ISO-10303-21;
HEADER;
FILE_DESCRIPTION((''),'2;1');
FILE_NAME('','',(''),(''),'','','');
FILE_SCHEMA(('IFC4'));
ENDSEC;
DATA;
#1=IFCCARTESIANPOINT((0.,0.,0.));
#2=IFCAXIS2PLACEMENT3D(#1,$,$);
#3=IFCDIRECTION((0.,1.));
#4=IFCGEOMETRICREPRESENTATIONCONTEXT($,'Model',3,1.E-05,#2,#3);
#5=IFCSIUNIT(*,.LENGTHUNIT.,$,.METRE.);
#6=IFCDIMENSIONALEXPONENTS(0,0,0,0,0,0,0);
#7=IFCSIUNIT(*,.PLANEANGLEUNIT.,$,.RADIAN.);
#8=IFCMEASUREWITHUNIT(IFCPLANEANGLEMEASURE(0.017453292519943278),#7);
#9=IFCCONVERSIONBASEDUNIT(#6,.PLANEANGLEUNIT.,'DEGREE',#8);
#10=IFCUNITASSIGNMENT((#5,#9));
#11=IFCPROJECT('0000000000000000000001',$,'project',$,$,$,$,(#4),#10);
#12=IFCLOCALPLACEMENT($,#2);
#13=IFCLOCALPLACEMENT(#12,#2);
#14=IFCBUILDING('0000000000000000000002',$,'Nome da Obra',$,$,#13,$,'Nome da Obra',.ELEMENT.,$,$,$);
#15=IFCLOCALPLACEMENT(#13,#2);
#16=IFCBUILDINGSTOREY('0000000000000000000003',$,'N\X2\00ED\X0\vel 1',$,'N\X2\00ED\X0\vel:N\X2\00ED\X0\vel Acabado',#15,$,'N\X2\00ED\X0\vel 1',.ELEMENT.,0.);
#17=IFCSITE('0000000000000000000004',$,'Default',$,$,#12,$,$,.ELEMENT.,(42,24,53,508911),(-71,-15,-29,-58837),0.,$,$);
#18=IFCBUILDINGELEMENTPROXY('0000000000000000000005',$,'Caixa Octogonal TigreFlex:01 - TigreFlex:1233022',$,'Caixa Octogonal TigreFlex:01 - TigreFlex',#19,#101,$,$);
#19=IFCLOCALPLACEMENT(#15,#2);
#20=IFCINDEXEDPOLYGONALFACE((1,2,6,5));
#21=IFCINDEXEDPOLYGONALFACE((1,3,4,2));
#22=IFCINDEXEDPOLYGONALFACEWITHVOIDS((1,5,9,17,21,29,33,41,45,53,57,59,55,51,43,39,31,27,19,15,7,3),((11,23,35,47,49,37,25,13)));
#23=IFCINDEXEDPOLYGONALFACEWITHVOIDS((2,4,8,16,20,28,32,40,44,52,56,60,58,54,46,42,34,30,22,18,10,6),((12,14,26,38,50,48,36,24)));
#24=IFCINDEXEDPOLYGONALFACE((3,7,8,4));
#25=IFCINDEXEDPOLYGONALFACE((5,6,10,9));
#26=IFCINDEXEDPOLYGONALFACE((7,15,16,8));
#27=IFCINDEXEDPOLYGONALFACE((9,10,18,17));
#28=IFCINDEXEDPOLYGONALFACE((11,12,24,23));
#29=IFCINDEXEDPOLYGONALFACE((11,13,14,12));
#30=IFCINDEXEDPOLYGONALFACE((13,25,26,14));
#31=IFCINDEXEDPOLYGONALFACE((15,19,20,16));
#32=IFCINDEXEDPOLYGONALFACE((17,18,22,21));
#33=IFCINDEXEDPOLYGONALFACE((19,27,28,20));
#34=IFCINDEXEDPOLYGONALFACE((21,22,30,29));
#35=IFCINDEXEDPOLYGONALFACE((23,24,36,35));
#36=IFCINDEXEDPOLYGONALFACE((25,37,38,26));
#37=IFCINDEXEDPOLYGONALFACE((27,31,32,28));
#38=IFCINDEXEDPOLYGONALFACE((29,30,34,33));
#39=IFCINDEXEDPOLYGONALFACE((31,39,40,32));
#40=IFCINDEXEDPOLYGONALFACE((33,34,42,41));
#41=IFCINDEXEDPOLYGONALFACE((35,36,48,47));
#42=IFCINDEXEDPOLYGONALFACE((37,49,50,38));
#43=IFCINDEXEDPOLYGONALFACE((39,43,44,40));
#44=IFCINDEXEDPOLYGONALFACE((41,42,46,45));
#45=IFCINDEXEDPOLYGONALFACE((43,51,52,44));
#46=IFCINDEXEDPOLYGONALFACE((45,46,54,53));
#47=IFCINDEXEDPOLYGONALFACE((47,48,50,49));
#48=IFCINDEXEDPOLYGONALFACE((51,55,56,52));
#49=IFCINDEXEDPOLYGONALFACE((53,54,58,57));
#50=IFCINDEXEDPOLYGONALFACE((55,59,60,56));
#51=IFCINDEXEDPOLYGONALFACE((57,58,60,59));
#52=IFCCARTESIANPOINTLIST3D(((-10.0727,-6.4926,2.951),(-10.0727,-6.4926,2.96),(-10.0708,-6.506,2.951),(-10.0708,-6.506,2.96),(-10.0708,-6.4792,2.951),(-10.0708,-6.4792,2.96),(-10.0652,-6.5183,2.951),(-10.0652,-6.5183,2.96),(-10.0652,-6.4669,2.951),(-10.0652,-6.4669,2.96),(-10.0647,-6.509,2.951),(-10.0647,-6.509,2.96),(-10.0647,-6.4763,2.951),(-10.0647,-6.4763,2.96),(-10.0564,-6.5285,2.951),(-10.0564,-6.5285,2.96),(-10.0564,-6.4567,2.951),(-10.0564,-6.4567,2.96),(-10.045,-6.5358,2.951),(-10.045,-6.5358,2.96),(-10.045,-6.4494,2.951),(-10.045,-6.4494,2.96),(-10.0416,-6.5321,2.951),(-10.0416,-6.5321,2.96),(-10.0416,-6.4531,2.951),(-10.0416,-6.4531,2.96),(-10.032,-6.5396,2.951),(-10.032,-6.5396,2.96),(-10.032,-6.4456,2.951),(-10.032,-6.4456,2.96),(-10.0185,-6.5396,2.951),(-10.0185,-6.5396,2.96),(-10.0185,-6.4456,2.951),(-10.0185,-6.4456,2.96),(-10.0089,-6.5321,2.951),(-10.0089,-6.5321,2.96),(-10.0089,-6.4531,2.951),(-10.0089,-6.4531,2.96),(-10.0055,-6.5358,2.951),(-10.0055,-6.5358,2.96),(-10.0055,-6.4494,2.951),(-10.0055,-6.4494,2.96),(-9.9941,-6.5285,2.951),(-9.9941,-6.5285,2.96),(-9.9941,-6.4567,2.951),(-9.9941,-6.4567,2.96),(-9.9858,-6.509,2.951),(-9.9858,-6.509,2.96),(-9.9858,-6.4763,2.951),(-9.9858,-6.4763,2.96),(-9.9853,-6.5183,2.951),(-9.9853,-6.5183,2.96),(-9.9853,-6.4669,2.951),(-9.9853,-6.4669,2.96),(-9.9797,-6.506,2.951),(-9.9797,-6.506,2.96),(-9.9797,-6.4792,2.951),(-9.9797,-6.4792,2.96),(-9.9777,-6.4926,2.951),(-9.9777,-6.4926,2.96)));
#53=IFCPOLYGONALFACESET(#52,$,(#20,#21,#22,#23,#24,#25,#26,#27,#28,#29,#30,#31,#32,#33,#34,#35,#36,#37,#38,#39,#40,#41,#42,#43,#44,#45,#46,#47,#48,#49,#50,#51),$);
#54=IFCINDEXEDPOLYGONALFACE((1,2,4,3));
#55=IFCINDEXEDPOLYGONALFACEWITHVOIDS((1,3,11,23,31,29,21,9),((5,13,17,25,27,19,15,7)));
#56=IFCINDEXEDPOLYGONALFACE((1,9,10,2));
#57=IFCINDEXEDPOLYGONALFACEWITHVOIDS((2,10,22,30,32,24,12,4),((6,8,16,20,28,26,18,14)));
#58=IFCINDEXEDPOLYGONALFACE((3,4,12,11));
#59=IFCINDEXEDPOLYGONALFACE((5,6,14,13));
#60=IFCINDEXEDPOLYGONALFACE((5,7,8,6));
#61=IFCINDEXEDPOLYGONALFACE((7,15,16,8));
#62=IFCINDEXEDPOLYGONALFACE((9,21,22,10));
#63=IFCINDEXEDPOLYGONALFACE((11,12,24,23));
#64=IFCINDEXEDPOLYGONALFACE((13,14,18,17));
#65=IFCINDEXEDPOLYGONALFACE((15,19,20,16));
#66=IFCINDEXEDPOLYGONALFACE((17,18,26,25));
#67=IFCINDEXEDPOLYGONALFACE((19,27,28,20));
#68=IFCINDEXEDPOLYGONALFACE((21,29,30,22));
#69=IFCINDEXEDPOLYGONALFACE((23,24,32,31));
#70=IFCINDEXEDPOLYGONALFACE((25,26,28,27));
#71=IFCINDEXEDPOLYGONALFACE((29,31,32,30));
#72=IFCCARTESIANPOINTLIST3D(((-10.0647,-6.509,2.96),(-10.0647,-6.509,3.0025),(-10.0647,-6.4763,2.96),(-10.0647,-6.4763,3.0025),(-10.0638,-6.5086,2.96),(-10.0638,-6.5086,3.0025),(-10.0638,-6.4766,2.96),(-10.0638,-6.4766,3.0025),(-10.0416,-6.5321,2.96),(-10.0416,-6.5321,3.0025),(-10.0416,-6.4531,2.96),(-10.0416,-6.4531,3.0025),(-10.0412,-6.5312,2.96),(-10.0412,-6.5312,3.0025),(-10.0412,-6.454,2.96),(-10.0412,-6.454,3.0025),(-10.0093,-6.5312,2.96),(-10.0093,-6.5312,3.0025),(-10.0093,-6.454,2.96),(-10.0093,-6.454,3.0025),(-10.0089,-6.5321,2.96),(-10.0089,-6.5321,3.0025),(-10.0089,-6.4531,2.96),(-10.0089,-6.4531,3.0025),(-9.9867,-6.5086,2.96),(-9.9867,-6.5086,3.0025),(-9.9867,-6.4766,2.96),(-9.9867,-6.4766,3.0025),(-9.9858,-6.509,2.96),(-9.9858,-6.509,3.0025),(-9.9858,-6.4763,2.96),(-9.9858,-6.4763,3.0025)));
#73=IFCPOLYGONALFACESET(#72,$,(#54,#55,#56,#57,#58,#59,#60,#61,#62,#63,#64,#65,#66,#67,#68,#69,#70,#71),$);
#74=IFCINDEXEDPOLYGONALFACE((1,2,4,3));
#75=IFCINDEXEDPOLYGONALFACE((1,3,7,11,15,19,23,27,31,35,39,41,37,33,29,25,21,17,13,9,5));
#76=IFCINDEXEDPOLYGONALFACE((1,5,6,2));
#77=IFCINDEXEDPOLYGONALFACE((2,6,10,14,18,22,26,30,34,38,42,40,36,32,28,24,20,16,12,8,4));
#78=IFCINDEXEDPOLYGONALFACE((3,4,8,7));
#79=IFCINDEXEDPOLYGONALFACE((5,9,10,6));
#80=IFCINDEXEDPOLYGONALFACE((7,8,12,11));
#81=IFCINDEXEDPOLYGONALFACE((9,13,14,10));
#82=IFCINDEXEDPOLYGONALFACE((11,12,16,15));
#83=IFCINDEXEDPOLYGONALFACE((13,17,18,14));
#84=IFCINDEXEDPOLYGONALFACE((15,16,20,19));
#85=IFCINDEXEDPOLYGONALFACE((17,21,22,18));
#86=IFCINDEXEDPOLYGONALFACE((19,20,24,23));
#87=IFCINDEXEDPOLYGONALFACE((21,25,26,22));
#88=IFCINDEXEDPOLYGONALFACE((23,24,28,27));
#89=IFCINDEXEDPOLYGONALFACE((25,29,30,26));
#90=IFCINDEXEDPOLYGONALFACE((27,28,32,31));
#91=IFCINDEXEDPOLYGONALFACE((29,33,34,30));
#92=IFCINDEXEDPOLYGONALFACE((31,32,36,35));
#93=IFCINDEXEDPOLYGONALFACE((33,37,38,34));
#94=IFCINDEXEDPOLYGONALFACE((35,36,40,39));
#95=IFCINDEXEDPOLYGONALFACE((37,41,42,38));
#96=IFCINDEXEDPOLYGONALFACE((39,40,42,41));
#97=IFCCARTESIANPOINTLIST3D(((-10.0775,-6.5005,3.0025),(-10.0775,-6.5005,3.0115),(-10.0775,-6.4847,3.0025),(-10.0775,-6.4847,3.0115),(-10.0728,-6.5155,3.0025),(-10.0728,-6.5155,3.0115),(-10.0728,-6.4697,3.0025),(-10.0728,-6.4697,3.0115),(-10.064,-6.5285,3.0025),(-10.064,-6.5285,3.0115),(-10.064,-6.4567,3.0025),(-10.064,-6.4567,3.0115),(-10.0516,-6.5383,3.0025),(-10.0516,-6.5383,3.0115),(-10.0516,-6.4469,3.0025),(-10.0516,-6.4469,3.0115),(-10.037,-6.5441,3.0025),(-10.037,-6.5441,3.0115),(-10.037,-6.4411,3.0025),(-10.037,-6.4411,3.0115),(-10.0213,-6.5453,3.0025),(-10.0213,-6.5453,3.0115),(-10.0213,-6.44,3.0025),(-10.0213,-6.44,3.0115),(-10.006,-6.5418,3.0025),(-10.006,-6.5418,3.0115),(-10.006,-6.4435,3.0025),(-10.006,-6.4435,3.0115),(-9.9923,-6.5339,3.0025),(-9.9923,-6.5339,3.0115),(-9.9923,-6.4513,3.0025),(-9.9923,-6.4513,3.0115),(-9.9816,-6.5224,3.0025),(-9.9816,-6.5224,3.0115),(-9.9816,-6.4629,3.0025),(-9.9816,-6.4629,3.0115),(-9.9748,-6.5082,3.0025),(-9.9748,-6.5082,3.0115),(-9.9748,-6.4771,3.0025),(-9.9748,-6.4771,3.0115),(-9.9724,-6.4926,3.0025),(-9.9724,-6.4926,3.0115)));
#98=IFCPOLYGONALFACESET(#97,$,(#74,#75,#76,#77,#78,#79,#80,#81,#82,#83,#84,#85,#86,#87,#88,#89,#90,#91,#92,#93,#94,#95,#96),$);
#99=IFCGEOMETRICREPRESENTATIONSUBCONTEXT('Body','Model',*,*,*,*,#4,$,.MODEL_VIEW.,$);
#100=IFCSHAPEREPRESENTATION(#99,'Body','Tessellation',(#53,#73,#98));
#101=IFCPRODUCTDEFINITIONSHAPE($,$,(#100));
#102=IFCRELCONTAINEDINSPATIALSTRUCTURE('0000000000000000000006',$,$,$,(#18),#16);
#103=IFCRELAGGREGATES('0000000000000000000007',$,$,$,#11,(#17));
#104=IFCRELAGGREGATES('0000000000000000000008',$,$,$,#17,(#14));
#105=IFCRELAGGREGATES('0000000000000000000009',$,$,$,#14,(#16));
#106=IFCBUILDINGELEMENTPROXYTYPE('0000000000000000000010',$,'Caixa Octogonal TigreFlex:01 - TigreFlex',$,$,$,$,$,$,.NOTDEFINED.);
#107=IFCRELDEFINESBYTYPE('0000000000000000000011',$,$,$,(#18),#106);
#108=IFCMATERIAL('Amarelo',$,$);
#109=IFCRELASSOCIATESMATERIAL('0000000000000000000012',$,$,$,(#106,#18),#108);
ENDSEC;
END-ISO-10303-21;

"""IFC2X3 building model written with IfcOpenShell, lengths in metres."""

from ifc_helpers import new_model, entity, si_unit, converted_unit, direction, frame, frame_2d, origin, origin_2d_with_axis, place, context, subcontext, project, spatial, polyline, circle_curve, parameter, trimmed, segment, composite_curve, circle, outline, extrude, source, transform, mapped, material, type_object, type_shapes, element, save


model = new_model("IFC2X3")

# Units and contexts
model_context = context("Model", 3, precision=1e-05, world=origin(), true_north=direction((0.0, 1.0)))
body_context = subcontext(model_context, "Body", "Model", "MODEL_VIEW")
ifc_project = project(units=[si_unit("LENGTHUNIT", "METRE"), converted_unit("PLANEANGLEUNIT", "DEGREE", entity("IfcPlaneAngleMeasure", 0.017453292519943278), si_unit("PLANEANGLEUNIT", "RADIAN"), dimensions=[0, 0, 0, 0, 0, 0, 0])], contexts=[model_context])

# Site, building, storey
site_placement = place(None, origin())
site = spatial("IfcSite", under=ifc_project, at=site_placement, Name="Default", CompositionType="ELEMENT", RefLatitude=(42, 24, 53, 508911), RefLongitude=(-71, -15, -29, -58837), RefElevation=0.0)
building_placement = place(site_placement, origin())
building = spatial("IfcBuilding", under=site, at=building_placement, Name="Nome da Obra", LongName="Nome da Obra", CompositionType="ELEMENT")
storey_placement = place(building_placement, origin())
storey = spatial("IfcBuildingStorey", under=building, at=storey_placement, Name="Nível 1", ObjectType="Nível:Nível Acabado", LongName="Nível 1", CompositionType="ELEMENT", Elevation=0.0)

# Building element proxy
ifc_material_1 = material(Name="Amarelo")
building_element_proxy_type_1 = type_object("IfcBuildingElementProxyType", Name="Caixa Octogonal TigreFlex:01 - TigreFlex", PredefinedType="NOTDEFINED", material=ifc_material_1)
shared_shape_1 = source(origin(), body_context, "Body", "SweptSolid", [
    extrude(outline(composite_curve([segment(trimmed(circle_curve(origin_2d_with_axis(), 0.0475), [parameter(180.0)], [parameter(360.0)], True, "PARAMETER"), True, "CONTINUOUS"), segment(trimmed(circle_curve(origin_2d_with_axis(), 0.0475), [parameter(0.0)], [parameter(180.0)], True, "PARAMETER"), True, "CONTINUOUS")], self_intersect=False), holes=[polyline([(-0.0395, 0.0164), (-0.0164, 0.0395), (0.0164, 0.0395), (0.0395, 0.0164), (0.0395, -0.0164), (0.0164, -0.0395), (-0.0164, -0.0395), (-0.0395, -0.0164), (-0.0395, 0.0164)])]), frame((0.0, 0.0, 2.7698)), (0.0, 0.0, 1.0), 0.009),
    extrude(outline(polyline([(-0.0164, -0.0395), (0.0164, -0.0395), (0.0395, -0.0164), (0.0395, 0.0164), (0.0164, 0.0395), (-0.0164, 0.0395), (-0.0395, 0.0164), (-0.0395, -0.0164), (-0.0164, -0.0395)]), holes=[polyline([(-0.016, -0.0386), (-0.0386, -0.016), (-0.0386, 0.016), (-0.016, 0.0386), (0.016, 0.0386), (0.0386, 0.016), (0.0386, -0.016), (0.016, -0.0386), (-0.016, -0.0386)])]), frame((0.0, 0.0, 2.7788), z_axis=(0.0, 0.0, 1.0), x_axis=(0.0, -1.0, 0.0)), (0.0, 0.0, 1.0), 0.0425),
    extrude(circle(Radius=0.0528, at=frame_2d((0.0, 0.0), x_axis=(1.0, 0.0))), frame((0.0, 0.0, 2.8213)), (0.0, 0.0, 1.0), 0.009),
])
type_shapes(building_element_proxy_type_1, [shared_shape_1])
proxy_1_placement = place(storey_placement, frame((-10.0252, -6.4926, 0.1813)))
element("IfcBuildingElementProxy", 1, at=proxy_1_placement, inside=storey, type_object=building_element_proxy_type_1, material=ifc_material_1, Name="Caixa Octogonal TigreFlex:01 - TigreFlex:1233022", ObjectType="Caixa Octogonal TigreFlex:01 - TigreFlex", context=body_context, shape_type="MappedRepresentation", body=[
    mapped(shared_shape_1, transform((0.0, 0.0, 0.0), scale=1.0)),
])

save(model, "model.ifc")
